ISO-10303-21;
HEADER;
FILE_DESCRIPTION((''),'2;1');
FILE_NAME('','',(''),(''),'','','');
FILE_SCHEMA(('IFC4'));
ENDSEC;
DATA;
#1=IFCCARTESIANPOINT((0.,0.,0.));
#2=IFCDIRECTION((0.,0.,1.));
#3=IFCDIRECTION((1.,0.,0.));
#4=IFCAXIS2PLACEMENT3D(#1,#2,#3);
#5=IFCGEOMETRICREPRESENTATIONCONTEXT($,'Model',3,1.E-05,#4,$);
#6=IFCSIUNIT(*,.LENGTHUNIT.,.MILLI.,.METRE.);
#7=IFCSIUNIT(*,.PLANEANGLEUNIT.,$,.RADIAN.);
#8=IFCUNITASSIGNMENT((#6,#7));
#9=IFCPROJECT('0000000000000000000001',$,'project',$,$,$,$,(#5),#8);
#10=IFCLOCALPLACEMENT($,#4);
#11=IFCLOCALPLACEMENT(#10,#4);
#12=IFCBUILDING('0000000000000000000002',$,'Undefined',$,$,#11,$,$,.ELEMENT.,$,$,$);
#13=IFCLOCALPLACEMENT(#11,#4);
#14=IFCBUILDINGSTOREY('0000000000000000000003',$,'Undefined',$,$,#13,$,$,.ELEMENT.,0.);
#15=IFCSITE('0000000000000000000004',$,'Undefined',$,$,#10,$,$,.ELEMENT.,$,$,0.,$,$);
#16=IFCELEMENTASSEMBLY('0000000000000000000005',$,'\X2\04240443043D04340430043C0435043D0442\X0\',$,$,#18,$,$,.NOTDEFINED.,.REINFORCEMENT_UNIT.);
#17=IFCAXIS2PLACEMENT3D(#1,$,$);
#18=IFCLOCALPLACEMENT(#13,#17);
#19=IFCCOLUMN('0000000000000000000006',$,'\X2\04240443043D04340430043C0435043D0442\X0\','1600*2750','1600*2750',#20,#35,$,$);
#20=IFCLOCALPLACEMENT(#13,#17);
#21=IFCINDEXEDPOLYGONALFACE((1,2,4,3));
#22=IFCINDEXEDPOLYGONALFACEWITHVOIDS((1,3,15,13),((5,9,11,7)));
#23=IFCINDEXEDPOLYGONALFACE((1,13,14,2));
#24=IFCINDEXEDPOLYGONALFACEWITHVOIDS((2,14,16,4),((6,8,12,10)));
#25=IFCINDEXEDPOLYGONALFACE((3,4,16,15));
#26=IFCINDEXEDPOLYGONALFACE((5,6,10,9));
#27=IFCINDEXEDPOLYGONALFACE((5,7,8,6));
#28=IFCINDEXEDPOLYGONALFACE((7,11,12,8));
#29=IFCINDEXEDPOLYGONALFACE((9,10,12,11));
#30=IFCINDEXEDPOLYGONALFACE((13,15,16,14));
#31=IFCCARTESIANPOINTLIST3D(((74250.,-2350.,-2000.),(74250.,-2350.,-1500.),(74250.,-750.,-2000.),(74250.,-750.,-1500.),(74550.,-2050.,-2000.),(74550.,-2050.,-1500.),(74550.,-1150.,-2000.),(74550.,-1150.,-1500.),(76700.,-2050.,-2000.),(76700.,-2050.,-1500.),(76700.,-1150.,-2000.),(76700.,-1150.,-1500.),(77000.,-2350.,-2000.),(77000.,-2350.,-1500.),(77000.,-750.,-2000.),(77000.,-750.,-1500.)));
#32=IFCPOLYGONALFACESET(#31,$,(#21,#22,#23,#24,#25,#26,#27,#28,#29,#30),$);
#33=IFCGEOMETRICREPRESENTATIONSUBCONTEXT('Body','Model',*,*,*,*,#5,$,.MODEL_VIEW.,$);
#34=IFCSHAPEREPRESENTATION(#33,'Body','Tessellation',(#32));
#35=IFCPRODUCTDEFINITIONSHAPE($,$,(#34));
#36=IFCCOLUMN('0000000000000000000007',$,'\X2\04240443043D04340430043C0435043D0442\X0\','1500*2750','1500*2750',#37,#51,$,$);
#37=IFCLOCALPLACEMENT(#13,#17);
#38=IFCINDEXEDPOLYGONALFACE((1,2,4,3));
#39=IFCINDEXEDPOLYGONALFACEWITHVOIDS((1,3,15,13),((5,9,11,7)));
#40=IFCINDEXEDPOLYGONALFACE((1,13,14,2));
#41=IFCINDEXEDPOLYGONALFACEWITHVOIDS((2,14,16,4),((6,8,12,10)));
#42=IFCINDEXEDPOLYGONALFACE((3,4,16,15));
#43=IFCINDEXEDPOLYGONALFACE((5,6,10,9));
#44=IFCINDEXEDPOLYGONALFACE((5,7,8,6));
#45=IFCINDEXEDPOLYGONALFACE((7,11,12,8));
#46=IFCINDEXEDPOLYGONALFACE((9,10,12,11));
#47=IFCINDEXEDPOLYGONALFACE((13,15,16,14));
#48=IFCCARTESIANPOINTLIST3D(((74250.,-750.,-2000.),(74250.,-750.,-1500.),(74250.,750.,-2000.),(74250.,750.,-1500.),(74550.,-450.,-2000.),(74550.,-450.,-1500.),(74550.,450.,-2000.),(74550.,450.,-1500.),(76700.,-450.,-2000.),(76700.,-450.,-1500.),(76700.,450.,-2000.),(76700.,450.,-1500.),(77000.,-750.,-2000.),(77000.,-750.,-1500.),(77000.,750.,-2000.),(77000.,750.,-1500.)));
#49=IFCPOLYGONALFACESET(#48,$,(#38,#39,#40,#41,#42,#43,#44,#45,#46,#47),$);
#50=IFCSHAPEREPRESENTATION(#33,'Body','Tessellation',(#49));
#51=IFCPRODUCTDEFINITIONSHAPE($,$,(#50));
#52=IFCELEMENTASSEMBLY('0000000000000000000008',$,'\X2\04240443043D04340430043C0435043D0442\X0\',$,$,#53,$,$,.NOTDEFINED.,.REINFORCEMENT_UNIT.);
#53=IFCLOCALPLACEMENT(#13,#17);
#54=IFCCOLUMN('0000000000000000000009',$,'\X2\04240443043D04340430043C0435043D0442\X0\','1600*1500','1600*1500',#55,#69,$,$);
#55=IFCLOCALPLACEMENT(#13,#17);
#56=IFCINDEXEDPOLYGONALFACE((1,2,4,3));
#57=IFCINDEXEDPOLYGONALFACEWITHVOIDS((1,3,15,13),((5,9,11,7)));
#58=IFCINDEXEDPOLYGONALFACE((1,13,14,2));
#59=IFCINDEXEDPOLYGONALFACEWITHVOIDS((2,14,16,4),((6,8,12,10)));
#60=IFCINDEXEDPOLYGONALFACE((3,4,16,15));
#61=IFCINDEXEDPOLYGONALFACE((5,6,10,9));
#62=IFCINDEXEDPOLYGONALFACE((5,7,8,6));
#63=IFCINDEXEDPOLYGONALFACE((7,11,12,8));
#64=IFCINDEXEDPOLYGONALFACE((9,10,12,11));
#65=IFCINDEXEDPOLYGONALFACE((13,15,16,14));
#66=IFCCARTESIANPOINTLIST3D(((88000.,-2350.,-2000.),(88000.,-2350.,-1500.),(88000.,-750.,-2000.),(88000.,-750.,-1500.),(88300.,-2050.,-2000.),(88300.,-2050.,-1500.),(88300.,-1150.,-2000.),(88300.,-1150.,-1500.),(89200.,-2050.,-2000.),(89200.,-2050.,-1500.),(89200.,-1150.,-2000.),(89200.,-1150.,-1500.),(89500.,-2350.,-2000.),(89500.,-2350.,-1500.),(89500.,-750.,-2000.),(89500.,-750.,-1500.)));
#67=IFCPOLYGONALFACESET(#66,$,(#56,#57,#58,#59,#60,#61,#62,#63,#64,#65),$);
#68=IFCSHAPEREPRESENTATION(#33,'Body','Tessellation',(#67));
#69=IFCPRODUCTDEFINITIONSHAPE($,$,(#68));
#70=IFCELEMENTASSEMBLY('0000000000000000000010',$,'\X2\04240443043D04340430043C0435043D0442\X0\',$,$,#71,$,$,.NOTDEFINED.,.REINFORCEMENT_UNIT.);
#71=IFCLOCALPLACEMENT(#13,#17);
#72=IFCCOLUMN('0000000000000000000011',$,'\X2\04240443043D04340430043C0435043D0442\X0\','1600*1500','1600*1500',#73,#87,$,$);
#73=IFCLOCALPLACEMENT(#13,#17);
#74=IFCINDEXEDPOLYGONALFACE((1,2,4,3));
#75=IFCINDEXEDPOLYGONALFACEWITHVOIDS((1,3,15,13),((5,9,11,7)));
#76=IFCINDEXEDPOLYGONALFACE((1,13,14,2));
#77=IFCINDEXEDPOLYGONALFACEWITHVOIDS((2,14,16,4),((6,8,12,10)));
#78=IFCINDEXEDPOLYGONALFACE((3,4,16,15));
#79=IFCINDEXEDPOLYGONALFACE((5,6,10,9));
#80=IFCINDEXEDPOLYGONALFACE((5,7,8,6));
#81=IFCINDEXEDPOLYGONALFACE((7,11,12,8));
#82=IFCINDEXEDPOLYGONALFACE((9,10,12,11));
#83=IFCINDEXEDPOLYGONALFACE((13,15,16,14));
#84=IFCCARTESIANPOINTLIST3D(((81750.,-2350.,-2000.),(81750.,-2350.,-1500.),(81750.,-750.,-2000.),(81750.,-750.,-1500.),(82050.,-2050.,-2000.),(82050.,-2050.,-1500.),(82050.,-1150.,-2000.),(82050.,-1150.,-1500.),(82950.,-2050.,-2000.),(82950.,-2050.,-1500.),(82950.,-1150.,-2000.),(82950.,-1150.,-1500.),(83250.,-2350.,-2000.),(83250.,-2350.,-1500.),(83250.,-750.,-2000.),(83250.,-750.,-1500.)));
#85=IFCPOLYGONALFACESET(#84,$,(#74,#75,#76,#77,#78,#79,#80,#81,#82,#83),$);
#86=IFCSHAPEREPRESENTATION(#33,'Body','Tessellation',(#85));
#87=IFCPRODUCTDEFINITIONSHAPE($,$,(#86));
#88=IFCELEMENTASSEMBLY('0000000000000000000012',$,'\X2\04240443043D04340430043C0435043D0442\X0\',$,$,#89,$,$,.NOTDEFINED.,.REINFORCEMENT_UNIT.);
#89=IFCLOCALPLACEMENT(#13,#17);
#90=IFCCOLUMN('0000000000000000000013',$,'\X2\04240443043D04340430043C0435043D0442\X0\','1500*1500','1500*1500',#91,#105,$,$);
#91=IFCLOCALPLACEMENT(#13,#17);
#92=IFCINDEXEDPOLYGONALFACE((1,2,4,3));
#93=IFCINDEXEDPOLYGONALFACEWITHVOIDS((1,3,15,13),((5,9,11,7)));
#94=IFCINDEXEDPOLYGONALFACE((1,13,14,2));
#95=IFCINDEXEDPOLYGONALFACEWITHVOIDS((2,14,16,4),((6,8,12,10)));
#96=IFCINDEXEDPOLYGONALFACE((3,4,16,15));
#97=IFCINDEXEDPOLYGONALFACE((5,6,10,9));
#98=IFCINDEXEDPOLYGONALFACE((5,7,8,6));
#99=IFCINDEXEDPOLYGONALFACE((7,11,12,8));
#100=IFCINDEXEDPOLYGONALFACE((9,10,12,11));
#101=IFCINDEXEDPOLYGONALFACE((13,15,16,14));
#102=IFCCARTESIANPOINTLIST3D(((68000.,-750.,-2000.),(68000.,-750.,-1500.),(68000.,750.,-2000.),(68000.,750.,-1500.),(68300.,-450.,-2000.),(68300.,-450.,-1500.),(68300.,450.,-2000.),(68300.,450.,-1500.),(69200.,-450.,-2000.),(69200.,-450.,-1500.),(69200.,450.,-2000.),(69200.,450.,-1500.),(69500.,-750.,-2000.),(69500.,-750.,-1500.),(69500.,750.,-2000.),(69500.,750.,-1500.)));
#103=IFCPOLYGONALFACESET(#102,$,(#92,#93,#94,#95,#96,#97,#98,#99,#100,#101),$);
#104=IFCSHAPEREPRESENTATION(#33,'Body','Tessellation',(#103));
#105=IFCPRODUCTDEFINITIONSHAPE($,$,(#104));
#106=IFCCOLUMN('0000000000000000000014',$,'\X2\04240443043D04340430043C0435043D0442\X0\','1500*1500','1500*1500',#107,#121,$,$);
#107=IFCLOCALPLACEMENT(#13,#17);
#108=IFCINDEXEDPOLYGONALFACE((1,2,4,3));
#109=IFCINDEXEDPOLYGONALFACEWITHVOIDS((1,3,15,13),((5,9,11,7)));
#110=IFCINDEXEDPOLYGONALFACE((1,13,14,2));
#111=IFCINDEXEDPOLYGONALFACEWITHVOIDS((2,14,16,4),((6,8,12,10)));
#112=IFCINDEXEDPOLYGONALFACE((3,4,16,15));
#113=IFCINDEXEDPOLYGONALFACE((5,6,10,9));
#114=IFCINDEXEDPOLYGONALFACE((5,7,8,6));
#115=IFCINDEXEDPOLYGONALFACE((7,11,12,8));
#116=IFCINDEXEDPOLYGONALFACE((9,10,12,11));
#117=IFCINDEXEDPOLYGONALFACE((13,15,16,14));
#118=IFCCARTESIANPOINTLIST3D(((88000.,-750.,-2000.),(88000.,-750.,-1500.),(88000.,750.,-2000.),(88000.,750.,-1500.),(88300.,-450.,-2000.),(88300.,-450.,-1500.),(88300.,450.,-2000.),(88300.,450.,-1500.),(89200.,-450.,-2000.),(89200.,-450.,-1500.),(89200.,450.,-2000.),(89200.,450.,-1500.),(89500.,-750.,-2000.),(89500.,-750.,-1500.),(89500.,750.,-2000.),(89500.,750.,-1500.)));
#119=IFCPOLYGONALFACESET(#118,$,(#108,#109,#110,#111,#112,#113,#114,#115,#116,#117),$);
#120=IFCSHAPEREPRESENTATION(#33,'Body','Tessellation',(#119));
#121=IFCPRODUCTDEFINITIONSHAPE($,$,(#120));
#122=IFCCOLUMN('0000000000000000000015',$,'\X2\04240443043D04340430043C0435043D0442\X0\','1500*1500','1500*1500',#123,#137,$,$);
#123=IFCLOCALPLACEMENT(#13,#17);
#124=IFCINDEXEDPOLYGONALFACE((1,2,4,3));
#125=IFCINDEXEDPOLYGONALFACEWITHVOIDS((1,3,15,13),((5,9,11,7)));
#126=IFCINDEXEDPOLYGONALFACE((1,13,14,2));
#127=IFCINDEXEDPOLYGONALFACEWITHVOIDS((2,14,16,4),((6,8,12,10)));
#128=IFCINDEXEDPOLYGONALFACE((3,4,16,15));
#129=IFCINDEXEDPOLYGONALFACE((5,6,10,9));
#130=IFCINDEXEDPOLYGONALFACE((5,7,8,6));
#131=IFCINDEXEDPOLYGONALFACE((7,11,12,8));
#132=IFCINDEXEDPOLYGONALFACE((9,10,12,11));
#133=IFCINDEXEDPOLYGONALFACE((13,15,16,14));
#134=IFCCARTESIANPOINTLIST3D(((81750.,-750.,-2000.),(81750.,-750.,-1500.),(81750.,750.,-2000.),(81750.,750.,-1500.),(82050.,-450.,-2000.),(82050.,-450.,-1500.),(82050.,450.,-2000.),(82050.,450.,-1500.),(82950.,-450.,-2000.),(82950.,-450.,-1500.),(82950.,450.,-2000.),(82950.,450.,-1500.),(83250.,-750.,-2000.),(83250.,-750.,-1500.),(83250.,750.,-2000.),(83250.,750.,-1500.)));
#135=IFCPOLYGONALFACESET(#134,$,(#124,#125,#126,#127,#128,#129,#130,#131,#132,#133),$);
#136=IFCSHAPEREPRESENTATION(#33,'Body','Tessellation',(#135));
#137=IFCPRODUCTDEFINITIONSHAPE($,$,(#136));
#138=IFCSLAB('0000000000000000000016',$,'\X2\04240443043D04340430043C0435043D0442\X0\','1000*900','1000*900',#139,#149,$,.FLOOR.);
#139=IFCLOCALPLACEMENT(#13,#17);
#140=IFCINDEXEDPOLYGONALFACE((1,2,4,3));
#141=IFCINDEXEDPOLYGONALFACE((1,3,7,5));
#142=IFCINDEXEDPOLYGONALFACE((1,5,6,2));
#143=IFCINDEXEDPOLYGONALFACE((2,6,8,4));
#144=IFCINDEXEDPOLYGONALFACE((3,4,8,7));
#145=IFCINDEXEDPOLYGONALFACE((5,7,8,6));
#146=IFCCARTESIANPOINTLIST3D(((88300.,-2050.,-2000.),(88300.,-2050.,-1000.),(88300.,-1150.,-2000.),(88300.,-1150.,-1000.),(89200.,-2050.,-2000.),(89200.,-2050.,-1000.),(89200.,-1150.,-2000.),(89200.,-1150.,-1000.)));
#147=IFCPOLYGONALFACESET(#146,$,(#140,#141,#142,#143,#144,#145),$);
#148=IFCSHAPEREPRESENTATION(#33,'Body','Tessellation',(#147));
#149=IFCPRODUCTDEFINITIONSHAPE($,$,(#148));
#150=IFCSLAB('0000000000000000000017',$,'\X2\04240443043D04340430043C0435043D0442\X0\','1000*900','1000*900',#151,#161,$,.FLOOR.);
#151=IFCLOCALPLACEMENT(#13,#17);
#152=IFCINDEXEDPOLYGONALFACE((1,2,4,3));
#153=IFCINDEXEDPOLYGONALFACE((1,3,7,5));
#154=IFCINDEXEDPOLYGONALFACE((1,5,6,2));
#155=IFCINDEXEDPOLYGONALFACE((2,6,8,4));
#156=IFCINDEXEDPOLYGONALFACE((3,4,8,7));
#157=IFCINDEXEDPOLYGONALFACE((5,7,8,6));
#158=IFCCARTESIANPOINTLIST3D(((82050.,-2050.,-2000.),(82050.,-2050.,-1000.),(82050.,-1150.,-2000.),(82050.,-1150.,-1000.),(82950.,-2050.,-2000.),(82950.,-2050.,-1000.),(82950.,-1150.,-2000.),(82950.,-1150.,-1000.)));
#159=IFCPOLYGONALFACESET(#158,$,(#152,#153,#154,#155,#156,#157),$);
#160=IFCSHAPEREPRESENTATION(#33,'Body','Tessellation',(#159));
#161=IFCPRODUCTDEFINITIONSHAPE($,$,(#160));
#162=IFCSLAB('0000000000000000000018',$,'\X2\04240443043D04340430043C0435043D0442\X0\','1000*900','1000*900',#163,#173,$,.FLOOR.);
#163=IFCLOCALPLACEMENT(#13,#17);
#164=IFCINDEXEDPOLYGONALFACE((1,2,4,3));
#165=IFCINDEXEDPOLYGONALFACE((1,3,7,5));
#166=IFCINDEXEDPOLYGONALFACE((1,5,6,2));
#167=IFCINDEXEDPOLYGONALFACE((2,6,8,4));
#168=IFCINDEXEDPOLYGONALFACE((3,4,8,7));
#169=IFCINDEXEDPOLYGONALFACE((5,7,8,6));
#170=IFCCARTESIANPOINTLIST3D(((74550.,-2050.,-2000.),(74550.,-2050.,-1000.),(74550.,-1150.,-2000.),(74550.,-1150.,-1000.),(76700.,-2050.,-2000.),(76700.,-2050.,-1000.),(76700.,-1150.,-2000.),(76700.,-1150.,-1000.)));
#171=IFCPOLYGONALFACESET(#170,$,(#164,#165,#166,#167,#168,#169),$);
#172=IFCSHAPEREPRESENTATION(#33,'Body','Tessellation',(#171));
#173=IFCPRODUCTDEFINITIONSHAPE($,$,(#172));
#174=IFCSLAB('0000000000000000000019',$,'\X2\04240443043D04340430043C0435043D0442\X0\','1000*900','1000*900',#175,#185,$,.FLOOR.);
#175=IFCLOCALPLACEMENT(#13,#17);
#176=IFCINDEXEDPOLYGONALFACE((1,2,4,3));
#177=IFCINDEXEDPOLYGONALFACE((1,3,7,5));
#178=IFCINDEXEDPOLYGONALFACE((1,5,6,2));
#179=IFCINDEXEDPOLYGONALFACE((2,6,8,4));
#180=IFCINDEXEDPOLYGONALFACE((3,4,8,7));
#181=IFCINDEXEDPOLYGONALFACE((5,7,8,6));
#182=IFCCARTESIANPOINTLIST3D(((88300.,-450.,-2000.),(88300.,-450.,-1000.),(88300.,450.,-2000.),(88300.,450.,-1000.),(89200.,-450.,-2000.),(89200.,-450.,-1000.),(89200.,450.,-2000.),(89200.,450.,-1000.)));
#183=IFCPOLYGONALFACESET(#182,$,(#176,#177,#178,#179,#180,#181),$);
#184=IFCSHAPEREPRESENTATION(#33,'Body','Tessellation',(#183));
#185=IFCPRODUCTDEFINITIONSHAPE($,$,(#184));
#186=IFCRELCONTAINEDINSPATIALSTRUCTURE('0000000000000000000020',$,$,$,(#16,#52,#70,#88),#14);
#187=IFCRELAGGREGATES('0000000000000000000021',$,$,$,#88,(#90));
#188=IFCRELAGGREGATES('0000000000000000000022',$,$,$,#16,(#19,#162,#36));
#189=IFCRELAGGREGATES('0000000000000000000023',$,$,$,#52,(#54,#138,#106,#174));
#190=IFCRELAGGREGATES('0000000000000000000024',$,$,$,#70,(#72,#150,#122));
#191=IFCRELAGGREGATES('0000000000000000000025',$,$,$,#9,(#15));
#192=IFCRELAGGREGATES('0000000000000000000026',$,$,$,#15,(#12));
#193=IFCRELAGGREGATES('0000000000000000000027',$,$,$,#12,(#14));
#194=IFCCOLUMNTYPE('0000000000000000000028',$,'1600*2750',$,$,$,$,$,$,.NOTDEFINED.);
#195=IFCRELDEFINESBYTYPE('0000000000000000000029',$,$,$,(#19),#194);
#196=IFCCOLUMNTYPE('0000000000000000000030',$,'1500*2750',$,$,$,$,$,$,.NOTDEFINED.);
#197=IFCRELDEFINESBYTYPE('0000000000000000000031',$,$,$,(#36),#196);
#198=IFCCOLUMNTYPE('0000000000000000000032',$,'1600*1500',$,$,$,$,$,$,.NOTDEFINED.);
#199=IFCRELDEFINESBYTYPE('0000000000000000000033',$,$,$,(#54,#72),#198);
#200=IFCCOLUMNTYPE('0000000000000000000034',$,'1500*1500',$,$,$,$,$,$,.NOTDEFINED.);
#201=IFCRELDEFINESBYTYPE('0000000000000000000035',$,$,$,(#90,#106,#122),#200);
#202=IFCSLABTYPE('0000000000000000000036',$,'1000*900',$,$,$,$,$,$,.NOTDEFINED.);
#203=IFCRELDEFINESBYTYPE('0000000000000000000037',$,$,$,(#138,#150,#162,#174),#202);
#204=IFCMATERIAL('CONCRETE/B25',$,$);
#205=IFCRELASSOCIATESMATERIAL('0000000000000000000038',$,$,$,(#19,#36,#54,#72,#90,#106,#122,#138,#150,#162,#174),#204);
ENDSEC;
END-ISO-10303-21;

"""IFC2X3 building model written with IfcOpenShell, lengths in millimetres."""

from ifc_helpers import new_model, si_unit, frame, origin_with_axes, origin_2d_with_axis, place, context, subcontext, project, spatial, polyline, rectangle, outline, extrude, boolean, material, type_object, element, aggregate, save


model = new_model("IFC2X3")

# Units and contexts
model_context = context("Model", 3, precision=1e-05, world=origin_with_axes())
body_context = subcontext(model_context, "Body", "Model", "MODEL_VIEW")
ifc_project = project(units=[si_unit("LENGTHUNIT", "METRE", prefix="MILLI"), si_unit("PLANEANGLEUNIT", "RADIAN")], contexts=[model_context])

# Site, building, storey
site_placement = place(None, origin_with_axes())
site = spatial("IfcSite", under=ifc_project, at=site_placement, Name="Undefined", CompositionType="ELEMENT", RefElevation=0.0)
building_placement = place(site_placement, origin_with_axes())
building = spatial("IfcBuilding", under=site, at=building_placement, Name="Undefined", CompositionType="ELEMENT")
storey_placement = place(building_placement, origin_with_axes())
storey = spatial("IfcBuildingStorey", under=building, at=storey_placement, Name="Undefined", CompositionType="ELEMENT", Elevation=0.0)

# Element assembly, columns
assembly_1_placement = place(storey_placement, origin_with_axes())
assembly_1 = element("IfcElementAssembly", 1, at=assembly_1_placement, inside=storey, Name="Фундамент", AssemblyPlace="NOTDEFINED", PredefinedType="REINFORCEMENT_UNIT")
ifc_material_1 = material(Name="CONCRETE/B25")
column_type_1 = type_object("IfcColumnType", Name="1600*2750", PredefinedType="NOTDEFINED")
column_1_placement = place(assembly_1_placement, frame((75625.0, -1550.0, -2000.0), z_axis=(0.0, 0.0, 1.0), x_axis=(0.0, -1.0, 0.0)))
column_1 = element("IfcColumn", 2, at=column_1_placement, type_object=column_type_1, material=ifc_material_1, Name="Фундамент", Description="1600*2750", ObjectType="1600*2750", context=body_context, shape_type="CSG", body=[
    boolean("DIFFERENCE", extrude(rectangle(XDim=2750.0, YDim=1600.0, at=origin_2d_with_axis()), frame((0.0, 0.0, 500.0), z_axis=(0.0, 0.0, -1.0), x_axis=(0.0, 1.0, 0.0)), (0.0, 0.0, 1.0), 500.0), extrude(outline(polyline([(0.0, 0.0), (900.0, 0.0), (900.0, 2150.0), (0.0, 2150.0), (0.0, 0.0)])), frame((-400.0, -1075.0, -100.0), z_axis=(0.0, 0.0, 1.0), x_axis=(1.0, 0.0, 0.0)), (0.0, 0.0, 1.0), 700.0)),
])
column_type_2 = type_object("IfcColumnType", Name="1500*2750", PredefinedType="NOTDEFINED")
column_2_placement = place(assembly_1_placement, frame((75625.0, 0.0, -2000.0), z_axis=(0.0, 0.0, 1.0), x_axis=(0.0, -1.0, 0.0)))
column_2 = element("IfcColumn", 3, at=column_2_placement, type_object=column_type_2, material=ifc_material_1, Name="Фундамент", Description="1500*2750", ObjectType="1500*2750", context=body_context, shape_type="CSG", body=[
    boolean("DIFFERENCE", extrude(rectangle(XDim=2750.0, YDim=1500.0, at=origin_2d_with_axis()), frame((0.0, 0.0, 500.0), z_axis=(0.0, 0.0, -1.0), x_axis=(0.0, 1.0, 0.0)), (0.0, 0.0, 1.0), 500.0), extrude(outline(polyline([(0.0, 0.0), (900.0, 0.0), (900.0, 2150.0), (0.0, 2150.0), (0.0, 0.0)])), frame((-450.0, -1075.0, -100.0), z_axis=(0.0, 0.0, 1.0), x_axis=(1.0, 0.0, 0.0)), (0.0, 0.0, 1.0), 700.0)),
])

# Element assemblies, columns
assembly_2_placement = place(storey_placement, origin_with_axes())
assembly_2 = element("IfcElementAssembly", 4, at=assembly_2_placement, inside=storey, Name="Фундамент", AssemblyPlace="NOTDEFINED", PredefinedType="REINFORCEMENT_UNIT")
column_type_3 = type_object("IfcColumnType", Name="1600*1500", PredefinedType="NOTDEFINED")
column_3_placement = place(assembly_2_placement, frame((88750.0, -1550.0, -2000.0), z_axis=(0.0, 0.0, 1.0), x_axis=(0.0, -1.0, 0.0)))
column_3 = element("IfcColumn", 5, at=column_3_placement, type_object=column_type_3, material=ifc_material_1, Name="Фундамент", Description="1600*1500", ObjectType="1600*1500", context=body_context, shape_type="CSG", body=[
    boolean("DIFFERENCE", extrude(rectangle(XDim=1500.0, YDim=1600.0, at=origin_2d_with_axis()), frame((0.0, 0.0, 500.0), z_axis=(0.0, 0.0, -1.0), x_axis=(0.0, 1.0, 0.0)), (0.0, 0.0, 1.0), 500.0), extrude(outline(polyline([(0.0, 0.0), (900.0, 0.0), (900.0, 900.0), (0.0, 900.0), (0.0, 0.0)])), frame((-400.0, -450.0, -100.0), z_axis=(0.0, 0.0, 1.0), x_axis=(1.0, 0.0, 0.0)), (0.0, 0.0, 1.0), 700.0)),
])
assembly_3_placement = place(storey_placement, origin_with_axes())
assembly_3 = element("IfcElementAssembly", 6, at=assembly_3_placement, inside=storey, Name="Фундамент", AssemblyPlace="NOTDEFINED", PredefinedType="REINFORCEMENT_UNIT")
column_4_placement = place(assembly_3_placement, frame((82500.0, -1550.0, -2000.0), z_axis=(0.0, 0.0, 1.0), x_axis=(0.0, -1.0, 0.0)))
column_4 = element("IfcColumn", 7, at=column_4_placement, type_object=column_type_3, material=ifc_material_1, Name="Фундамент", Description="1600*1500", ObjectType="1600*1500", context=body_context, shape_type="CSG", body=[
    boolean("DIFFERENCE", extrude(rectangle(XDim=1500.0, YDim=1600.0, at=origin_2d_with_axis()), frame((0.0, 0.0, 500.0), z_axis=(0.0, 0.0, -1.0), x_axis=(0.0, 1.0, 0.0)), (0.0, 0.0, 1.0), 500.0), extrude(outline(polyline([(0.0, 0.0), (900.0, 0.0), (900.0, 900.0), (0.0, 900.0), (0.0, 0.0)])), frame((-400.0, -450.0, -100.0), z_axis=(0.0, 0.0, 1.0), x_axis=(1.0, 0.0, 0.0)), (0.0, 0.0, 1.0), 700.0)),
])
assembly_4_placement = place(storey_placement, origin_with_axes())
assembly_4 = element("IfcElementAssembly", 8, at=assembly_4_placement, inside=storey, Name="Фундамент", AssemblyPlace="NOTDEFINED", PredefinedType="REINFORCEMENT_UNIT")
column_type_4 = type_object("IfcColumnType", Name="1500*1500", PredefinedType="NOTDEFINED")
column_5_placement = place(assembly_4_placement, frame((68750.0, 0.0, -2000.0), z_axis=(0.0, 0.0, 1.0), x_axis=(0.0, -1.0, 0.0)))
column_5 = element("IfcColumn", 9, at=column_5_placement, type_object=column_type_4, material=ifc_material_1, Name="Фундамент", Description="1500*1500", ObjectType="1500*1500", context=body_context, shape_type="CSG", body=[
    boolean("DIFFERENCE", extrude(rectangle(XDim=1500.0, YDim=1500.0, at=origin_2d_with_axis()), frame((0.0, 0.0, 500.0), z_axis=(0.0, 0.0, -1.0), x_axis=(0.0, 1.0, 0.0)), (0.0, 0.0, 1.0), 500.0), extrude(outline(polyline([(0.0, 0.0), (900.0, 0.0), (900.0, 900.0), (0.0, 900.0), (0.0, 0.0)])), frame((-450.0, -450.0, -100.0), z_axis=(0.0, 0.0, 1.0), x_axis=(1.0, 0.0, 0.0)), (0.0, 0.0, 1.0), 700.0)),
])
aggregate(assembly_4, [column_5])

# Columns
column_6_placement = place(assembly_2_placement, frame((88750.0, 0.0, -2000.0), z_axis=(0.0, 0.0, 1.0), x_axis=(0.0, -1.0, 0.0)))
column_6 = element("IfcColumn", 10, at=column_6_placement, type_object=column_type_4, material=ifc_material_1, Name="Фундамент", Description="1500*1500", ObjectType="1500*1500", context=body_context, shape_type="CSG", body=[
    boolean("DIFFERENCE", extrude(rectangle(XDim=1500.0, YDim=1500.0, at=origin_2d_with_axis()), frame((0.0, 0.0, 500.0), z_axis=(0.0, 0.0, -1.0), x_axis=(0.0, 1.0, 0.0)), (0.0, 0.0, 1.0), 500.0), extrude(outline(polyline([(0.0, 0.0), (900.0, 0.0), (900.0, 900.0), (0.0, 900.0), (0.0, 0.0)])), frame((-450.0, -450.0, -100.0), z_axis=(0.0, 0.0, 1.0), x_axis=(1.0, 0.0, 0.0)), (0.0, 0.0, 1.0), 700.0)),
])
column_7_placement = place(assembly_3_placement, frame((82500.0, 0.0, -2000.0), z_axis=(0.0, 0.0, 1.0), x_axis=(0.0, -1.0, 0.0)))
column_7 = element("IfcColumn", 11, at=column_7_placement, type_object=column_type_4, material=ifc_material_1, Name="Фундамент", Description="1500*1500", ObjectType="1500*1500", context=body_context, shape_type="CSG", body=[
    boolean("DIFFERENCE", extrude(rectangle(XDim=1500.0, YDim=1500.0, at=origin_2d_with_axis()), frame((0.0, 0.0, 500.0), z_axis=(0.0, 0.0, -1.0), x_axis=(0.0, 1.0, 0.0)), (0.0, 0.0, 1.0), 500.0), extrude(outline(polyline([(0.0, 0.0), (900.0, 0.0), (900.0, 900.0), (0.0, 900.0), (0.0, 0.0)])), frame((-450.0, -450.0, -100.0), z_axis=(0.0, 0.0, 1.0), x_axis=(1.0, 0.0, 0.0)), (0.0, 0.0, 1.0), 700.0)),
])

# Slabs
slab_type_1 = type_object("IfcSlabType", Name="1000*900", PredefinedType="NOTDEFINED")
slab_1_placement = place(assembly_2_placement, frame((88300.0, -1150.0, -1500.0), z_axis=(0.0, 0.0, 1.0), x_axis=(0.0, -1.0, 0.0)))
slab_1 = element("IfcSlab", 12, at=slab_1_placement, type_object=slab_type_1, material=ifc_material_1, Name="Фундамент", Description="1000*900", ObjectType="1000*900", PredefinedType="FLOOR", context=body_context, shape_type="SweptSolid", body=[
    extrude(outline(polyline([(0.0, 0.0), (900.0, 0.0), (900.0, 900.0), (0.0, 900.0), (0.0, 0.0)])), frame((0.0, 0.0, -500.0), z_axis=(0.0, 0.0, 1.0), x_axis=(1.0, 0.0, 0.0)), (0.0, 0.0, 1.0), 1000.0),
])
slab_2_placement = place(assembly_3_placement, frame((82050.0, -1150.0, -1500.0), z_axis=(0.0, 0.0, 1.0), x_axis=(0.0, -1.0, 0.0)))
slab_2 = element("IfcSlab", 13, at=slab_2_placement, type_object=slab_type_1, material=ifc_material_1, Name="Фундамент", Description="1000*900", ObjectType="1000*900", PredefinedType="FLOOR", context=body_context, shape_type="SweptSolid", body=[
    extrude(outline(polyline([(0.0, 0.0), (900.0, 0.0), (900.0, 900.0), (0.0, 900.0), (0.0, 0.0)])), frame((0.0, 0.0, -500.0), z_axis=(0.0, 0.0, 1.0), x_axis=(1.0, 0.0, 0.0)), (0.0, 0.0, 1.0), 1000.0),
])
slab_3_placement = place(assembly_1_placement, frame((74550.0, -1150.0, -1500.0), z_axis=(0.0, 0.0, 1.0), x_axis=(0.0, -1.0, 0.0)))
slab_3 = element("IfcSlab", 14, at=slab_3_placement, type_object=slab_type_1, material=ifc_material_1, Name="Фундамент", Description="1000*900", ObjectType="1000*900", PredefinedType="FLOOR", context=body_context, shape_type="SweptSolid", body=[
    extrude(outline(polyline([(0.0, 0.0), (900.0, 0.0), (900.0, 2150.0), (0.0, 2150.0), (0.0, 0.0)])), frame((0.0, 0.0, -500.0), z_axis=(0.0, 0.0, 1.0), x_axis=(1.0, 0.0, 0.0)), (0.0, 0.0, 1.0), 1000.0),
])
slab_4_placement = place(assembly_2_placement, frame((88300.0, 450.0, -1500.0), z_axis=(0.0, 0.0, 1.0), x_axis=(0.0, -1.0, 0.0)))
slab_4 = element("IfcSlab", 15, at=slab_4_placement, type_object=slab_type_1, material=ifc_material_1, Name="Фундамент", Description="1000*900", ObjectType="1000*900", PredefinedType="FLOOR", context=body_context, shape_type="SweptSolid", body=[
    extrude(outline(polyline([(0.0, 0.0), (900.0, 0.0), (900.0, 900.0), (0.0, 900.0), (0.0, 0.0)])), frame((0.0, 0.0, -500.0), z_axis=(0.0, 0.0, 1.0), x_axis=(1.0, 0.0, 0.0)), (0.0, 0.0, 1.0), 1000.0),
])
aggregate(assembly_1, [column_1, slab_3, column_2])
aggregate(assembly_2, [column_3, slab_1, column_6, slab_4])
aggregate(assembly_3, [column_4, slab_2, column_7])

save(model, "model.ifc")
